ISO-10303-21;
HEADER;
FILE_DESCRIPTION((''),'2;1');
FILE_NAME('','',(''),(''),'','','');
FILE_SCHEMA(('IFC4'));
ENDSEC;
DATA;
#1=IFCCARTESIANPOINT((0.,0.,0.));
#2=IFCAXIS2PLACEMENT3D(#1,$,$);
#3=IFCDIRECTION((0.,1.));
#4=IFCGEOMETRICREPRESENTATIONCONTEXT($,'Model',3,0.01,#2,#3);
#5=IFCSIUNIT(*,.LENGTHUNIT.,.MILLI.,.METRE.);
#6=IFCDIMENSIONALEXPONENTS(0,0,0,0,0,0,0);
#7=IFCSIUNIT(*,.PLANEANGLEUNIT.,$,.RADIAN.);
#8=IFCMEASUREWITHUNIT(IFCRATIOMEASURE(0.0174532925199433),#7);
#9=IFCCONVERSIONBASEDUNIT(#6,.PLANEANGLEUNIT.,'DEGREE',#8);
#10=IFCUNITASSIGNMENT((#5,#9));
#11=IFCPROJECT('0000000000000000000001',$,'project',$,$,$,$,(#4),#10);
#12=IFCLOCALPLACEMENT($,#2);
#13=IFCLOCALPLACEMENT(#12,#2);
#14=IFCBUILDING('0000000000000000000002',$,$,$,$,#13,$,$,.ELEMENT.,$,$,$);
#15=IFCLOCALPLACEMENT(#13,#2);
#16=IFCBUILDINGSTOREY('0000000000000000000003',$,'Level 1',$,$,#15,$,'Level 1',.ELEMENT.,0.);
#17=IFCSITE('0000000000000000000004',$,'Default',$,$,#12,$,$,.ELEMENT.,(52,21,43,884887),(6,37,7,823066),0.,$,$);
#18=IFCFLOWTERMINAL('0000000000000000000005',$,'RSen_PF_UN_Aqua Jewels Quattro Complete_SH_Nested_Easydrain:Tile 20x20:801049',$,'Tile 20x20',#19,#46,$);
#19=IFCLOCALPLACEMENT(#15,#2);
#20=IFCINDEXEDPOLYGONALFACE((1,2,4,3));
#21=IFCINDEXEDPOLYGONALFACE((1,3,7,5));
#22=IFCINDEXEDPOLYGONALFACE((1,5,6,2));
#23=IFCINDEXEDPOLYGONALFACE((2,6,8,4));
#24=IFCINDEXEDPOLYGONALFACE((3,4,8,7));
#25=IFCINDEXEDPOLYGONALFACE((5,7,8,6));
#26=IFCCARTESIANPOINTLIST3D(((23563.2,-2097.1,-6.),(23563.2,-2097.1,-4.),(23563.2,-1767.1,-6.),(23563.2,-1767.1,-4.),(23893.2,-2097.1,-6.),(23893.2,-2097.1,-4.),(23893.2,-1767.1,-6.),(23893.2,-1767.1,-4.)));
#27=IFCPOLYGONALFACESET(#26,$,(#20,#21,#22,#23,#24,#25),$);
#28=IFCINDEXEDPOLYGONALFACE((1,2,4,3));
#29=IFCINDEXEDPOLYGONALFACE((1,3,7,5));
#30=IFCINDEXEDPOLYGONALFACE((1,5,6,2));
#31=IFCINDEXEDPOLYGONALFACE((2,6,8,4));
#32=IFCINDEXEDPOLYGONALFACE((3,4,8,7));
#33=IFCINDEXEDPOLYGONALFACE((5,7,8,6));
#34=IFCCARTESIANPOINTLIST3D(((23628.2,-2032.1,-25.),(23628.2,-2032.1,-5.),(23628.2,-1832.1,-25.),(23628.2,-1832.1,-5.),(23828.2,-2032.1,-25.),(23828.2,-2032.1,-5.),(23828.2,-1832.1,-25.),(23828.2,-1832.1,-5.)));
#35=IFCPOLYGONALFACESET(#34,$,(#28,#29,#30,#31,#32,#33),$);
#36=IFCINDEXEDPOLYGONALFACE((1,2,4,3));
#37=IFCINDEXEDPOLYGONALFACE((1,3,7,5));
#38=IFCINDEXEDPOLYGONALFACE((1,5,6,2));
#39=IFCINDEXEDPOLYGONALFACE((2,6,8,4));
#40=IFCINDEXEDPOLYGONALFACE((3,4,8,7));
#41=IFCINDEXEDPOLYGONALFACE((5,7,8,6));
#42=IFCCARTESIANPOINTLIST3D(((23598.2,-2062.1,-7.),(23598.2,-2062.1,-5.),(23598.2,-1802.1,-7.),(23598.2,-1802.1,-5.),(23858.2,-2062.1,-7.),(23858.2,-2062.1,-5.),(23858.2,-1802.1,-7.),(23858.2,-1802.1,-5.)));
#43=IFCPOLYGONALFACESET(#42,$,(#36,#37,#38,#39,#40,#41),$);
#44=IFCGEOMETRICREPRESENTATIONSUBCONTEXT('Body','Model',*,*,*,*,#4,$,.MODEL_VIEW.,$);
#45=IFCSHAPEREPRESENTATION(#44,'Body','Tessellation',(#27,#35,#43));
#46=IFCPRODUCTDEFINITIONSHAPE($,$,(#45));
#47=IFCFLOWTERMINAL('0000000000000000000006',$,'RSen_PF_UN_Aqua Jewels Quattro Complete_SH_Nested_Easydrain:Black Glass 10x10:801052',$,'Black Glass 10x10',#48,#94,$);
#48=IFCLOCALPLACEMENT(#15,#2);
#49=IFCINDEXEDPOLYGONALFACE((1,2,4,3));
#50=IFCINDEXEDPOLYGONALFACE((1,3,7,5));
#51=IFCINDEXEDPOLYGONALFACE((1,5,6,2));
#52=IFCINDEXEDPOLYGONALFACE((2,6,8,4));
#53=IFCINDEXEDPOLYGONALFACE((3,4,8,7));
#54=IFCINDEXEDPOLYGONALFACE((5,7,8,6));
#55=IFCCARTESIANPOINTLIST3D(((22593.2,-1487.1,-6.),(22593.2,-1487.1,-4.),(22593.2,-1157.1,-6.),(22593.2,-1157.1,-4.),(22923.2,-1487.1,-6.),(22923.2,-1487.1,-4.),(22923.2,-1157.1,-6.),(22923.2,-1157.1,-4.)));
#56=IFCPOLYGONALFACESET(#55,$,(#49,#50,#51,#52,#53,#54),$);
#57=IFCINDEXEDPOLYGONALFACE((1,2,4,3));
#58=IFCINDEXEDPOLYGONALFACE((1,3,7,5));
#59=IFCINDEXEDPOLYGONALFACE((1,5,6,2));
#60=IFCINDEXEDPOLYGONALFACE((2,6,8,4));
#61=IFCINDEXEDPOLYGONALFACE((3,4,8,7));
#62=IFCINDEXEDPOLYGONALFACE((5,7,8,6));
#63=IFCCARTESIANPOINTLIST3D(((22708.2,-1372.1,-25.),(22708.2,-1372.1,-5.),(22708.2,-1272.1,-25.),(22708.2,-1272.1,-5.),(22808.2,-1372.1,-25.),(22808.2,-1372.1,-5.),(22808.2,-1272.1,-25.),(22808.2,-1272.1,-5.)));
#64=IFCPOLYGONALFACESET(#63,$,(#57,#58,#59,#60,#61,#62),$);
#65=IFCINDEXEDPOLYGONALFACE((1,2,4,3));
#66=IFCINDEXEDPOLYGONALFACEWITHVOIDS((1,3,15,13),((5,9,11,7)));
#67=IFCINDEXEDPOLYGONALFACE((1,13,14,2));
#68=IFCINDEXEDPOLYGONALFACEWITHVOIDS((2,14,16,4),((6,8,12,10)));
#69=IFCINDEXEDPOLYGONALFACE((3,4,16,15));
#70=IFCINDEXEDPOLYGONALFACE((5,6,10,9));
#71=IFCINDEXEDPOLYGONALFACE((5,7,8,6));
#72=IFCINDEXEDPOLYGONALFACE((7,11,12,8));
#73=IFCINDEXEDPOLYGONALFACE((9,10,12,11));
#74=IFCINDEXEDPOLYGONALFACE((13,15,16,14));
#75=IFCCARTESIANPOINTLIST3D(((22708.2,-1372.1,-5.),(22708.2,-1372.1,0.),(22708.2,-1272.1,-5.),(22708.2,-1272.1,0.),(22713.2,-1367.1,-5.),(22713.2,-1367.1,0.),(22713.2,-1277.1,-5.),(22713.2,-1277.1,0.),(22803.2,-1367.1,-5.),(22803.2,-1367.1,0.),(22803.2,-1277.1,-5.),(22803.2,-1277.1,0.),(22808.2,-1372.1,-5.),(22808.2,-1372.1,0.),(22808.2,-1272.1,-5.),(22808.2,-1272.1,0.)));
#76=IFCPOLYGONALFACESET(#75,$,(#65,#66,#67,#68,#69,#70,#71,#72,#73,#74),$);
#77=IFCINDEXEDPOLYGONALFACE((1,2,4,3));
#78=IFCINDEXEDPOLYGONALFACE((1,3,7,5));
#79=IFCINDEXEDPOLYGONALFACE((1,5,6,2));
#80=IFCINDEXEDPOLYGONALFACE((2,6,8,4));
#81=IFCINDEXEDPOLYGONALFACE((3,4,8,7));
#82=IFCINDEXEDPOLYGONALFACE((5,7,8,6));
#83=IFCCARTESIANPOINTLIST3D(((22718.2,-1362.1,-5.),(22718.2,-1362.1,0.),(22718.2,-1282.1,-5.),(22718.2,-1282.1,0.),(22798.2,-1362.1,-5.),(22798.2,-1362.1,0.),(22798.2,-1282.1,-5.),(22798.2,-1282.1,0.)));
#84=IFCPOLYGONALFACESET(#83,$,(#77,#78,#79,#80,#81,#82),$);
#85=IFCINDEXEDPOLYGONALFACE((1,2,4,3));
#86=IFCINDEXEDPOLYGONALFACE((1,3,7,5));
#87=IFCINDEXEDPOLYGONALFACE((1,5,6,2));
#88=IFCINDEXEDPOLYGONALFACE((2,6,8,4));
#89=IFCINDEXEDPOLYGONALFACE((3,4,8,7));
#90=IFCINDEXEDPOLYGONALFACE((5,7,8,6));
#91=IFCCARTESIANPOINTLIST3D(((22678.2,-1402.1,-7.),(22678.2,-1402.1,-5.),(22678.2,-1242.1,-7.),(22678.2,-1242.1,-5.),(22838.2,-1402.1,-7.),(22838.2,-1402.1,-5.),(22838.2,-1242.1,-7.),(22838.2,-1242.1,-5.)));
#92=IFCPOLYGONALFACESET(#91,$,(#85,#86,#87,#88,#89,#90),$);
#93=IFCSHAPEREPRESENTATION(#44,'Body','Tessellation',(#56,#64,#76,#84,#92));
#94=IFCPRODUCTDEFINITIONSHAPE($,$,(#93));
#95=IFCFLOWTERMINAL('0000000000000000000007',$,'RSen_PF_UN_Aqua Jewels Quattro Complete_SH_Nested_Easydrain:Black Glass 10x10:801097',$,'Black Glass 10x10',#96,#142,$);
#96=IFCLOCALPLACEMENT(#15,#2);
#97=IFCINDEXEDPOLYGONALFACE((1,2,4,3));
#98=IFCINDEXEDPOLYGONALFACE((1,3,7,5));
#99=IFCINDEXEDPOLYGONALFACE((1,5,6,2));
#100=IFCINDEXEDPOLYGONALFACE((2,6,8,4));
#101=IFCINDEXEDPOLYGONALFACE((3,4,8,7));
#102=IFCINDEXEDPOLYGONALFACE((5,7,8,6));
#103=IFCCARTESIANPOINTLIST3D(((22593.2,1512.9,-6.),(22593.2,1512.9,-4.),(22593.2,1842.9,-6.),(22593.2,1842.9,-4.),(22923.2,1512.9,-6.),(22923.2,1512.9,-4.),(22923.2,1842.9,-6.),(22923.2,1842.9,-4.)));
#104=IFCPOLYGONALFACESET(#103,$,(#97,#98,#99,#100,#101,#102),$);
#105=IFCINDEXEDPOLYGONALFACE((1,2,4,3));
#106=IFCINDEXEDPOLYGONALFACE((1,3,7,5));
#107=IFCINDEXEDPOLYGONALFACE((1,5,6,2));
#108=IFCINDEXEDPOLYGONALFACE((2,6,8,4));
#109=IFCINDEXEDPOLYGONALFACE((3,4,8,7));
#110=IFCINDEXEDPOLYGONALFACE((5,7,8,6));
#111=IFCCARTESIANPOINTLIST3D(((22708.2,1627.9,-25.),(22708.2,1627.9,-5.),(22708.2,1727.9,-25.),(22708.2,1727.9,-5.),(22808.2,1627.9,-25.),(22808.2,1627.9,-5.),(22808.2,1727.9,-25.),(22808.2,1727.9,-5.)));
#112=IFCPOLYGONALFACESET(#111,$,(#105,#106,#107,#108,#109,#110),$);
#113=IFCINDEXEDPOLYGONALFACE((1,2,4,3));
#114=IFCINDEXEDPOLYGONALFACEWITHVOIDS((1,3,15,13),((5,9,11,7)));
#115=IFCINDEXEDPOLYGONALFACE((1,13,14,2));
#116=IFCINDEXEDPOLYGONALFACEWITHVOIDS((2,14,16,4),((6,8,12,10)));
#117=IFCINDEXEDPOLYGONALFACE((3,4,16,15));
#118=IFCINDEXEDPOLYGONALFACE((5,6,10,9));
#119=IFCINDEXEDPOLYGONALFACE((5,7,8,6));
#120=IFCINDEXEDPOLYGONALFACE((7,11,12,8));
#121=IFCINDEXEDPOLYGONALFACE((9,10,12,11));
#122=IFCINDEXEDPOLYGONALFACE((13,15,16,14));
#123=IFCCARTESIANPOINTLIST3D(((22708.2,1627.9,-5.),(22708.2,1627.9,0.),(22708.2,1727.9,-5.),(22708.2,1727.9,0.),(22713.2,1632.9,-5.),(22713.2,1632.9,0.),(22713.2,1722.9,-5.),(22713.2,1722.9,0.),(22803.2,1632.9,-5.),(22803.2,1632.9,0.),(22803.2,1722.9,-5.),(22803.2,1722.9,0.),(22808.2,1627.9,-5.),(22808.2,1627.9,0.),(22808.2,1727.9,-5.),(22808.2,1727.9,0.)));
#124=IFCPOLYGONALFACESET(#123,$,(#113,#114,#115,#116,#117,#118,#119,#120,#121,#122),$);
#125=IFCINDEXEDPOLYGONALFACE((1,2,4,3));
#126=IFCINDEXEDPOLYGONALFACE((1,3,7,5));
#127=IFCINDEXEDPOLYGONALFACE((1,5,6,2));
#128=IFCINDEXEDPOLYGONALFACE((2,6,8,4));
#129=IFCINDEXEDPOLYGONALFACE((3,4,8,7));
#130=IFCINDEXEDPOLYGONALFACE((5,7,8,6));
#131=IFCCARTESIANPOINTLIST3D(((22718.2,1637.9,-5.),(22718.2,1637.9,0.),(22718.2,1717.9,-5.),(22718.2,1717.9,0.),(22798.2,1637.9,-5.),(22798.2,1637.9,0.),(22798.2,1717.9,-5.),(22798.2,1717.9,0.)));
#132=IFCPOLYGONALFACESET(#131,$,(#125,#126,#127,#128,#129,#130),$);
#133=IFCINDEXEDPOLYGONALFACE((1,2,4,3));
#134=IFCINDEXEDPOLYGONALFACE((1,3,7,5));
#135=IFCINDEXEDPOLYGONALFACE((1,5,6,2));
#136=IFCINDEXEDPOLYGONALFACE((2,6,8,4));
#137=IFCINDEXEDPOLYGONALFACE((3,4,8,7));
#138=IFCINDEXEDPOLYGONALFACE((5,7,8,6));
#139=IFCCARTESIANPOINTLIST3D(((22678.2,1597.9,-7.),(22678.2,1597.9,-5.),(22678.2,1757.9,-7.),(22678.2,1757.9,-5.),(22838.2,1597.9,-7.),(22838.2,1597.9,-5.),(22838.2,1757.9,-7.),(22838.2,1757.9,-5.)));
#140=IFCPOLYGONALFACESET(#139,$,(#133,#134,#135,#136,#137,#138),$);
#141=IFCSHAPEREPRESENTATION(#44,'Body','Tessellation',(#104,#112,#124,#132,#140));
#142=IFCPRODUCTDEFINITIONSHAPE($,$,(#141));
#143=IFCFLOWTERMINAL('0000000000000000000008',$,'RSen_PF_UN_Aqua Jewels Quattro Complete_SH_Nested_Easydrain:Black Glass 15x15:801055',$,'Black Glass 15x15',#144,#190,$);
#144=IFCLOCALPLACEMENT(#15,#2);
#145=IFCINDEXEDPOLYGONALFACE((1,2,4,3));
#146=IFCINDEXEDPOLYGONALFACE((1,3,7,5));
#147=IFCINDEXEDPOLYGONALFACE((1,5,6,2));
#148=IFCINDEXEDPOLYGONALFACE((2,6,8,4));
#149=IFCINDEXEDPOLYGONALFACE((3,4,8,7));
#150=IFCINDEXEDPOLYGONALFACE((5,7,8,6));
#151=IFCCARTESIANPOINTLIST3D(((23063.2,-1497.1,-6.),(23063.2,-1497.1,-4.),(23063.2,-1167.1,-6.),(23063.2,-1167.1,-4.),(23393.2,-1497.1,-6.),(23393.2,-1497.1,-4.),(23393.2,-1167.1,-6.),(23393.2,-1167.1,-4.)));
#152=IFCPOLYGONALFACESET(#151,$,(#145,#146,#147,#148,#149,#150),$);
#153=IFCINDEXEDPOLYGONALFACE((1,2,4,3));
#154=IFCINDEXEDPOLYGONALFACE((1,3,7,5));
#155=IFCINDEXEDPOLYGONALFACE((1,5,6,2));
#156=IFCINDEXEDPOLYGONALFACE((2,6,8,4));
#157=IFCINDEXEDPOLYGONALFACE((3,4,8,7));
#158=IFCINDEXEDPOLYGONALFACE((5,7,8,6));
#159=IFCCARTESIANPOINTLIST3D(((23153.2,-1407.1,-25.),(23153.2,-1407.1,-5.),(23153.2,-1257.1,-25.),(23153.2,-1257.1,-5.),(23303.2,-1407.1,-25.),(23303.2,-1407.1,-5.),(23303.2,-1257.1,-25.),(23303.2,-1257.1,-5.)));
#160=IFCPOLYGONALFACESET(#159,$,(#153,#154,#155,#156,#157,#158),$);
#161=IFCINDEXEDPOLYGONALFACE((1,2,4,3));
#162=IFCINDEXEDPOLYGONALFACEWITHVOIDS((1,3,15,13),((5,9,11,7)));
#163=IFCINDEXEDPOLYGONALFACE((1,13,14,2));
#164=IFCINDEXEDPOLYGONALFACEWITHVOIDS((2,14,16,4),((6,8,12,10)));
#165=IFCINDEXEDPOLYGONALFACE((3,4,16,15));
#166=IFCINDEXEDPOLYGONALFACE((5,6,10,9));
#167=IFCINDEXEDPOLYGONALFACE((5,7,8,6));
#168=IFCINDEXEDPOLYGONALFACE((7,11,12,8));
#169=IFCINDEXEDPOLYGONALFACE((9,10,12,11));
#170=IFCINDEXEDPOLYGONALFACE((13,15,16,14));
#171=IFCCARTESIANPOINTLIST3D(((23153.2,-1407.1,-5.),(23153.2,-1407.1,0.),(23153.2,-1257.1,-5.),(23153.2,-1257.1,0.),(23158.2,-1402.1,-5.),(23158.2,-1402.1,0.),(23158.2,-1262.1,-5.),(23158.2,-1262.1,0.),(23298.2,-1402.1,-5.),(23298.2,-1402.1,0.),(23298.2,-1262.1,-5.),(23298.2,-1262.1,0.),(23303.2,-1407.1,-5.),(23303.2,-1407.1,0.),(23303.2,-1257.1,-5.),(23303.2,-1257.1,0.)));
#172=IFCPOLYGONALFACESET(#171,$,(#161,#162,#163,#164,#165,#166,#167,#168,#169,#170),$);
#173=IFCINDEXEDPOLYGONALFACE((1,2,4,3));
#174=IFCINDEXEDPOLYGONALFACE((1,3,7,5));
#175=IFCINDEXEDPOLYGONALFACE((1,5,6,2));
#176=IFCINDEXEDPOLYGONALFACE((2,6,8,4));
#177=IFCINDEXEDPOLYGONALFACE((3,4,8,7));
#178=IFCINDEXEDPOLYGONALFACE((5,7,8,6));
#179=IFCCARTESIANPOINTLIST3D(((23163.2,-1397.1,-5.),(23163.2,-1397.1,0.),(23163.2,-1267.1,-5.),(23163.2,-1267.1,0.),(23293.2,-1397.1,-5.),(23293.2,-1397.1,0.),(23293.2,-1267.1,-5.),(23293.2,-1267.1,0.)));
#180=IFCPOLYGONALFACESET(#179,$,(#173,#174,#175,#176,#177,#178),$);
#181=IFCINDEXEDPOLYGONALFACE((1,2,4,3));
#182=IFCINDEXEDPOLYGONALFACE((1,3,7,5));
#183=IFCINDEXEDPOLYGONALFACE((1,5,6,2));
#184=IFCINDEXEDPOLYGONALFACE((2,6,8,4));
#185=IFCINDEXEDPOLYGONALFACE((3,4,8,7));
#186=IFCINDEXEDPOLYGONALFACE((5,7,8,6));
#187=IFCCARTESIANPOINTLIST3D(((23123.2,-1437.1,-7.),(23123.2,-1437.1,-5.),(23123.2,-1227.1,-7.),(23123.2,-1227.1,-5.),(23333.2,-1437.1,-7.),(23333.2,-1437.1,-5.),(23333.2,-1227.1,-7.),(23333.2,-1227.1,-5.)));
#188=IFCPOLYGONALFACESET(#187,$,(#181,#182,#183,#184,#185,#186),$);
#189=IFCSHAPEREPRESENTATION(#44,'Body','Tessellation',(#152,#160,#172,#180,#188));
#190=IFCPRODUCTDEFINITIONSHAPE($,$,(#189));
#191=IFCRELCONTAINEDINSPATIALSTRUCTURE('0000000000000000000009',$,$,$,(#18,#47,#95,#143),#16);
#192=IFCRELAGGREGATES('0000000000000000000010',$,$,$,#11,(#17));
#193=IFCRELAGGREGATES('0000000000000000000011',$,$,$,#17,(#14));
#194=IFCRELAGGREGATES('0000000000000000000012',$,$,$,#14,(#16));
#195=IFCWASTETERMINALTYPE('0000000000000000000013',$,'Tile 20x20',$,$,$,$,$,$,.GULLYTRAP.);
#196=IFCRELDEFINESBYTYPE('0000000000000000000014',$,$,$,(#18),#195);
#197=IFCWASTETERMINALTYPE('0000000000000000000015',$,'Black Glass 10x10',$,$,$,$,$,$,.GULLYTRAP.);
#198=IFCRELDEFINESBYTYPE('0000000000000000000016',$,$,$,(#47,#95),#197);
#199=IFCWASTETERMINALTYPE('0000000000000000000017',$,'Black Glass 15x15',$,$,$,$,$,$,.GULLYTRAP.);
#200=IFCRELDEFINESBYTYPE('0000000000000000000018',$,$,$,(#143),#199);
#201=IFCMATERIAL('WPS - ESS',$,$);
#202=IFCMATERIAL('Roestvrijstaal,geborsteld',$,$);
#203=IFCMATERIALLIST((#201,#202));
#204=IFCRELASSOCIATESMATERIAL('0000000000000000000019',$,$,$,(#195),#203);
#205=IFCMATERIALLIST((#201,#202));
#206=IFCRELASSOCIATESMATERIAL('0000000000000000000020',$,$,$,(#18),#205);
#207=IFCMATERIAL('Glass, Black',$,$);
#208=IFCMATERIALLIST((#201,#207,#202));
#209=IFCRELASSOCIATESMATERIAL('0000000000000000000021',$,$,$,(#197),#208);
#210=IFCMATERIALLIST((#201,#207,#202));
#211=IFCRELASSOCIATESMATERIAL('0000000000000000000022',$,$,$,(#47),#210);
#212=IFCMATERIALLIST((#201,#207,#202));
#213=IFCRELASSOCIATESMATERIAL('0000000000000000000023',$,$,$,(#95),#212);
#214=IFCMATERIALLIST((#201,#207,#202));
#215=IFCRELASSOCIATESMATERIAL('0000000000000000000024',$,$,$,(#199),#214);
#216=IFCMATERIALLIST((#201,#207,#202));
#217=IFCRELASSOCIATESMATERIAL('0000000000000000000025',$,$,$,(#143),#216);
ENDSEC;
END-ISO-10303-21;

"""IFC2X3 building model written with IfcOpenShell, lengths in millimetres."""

from ifc_helpers import new_model, entity, si_unit, converted_unit, direction, frame, frame_2d, origin, origin_2d_with_axis, place, context, subcontext, project, spatial, polyline, rectangle, outline, extrude, source, transform, mapped, material, material_list, type_object, type_shapes, element, save


model = new_model("IFC2X3")

# Units and contexts
model_context = context("Model", 3, precision=0.01, world=origin(), true_north=direction((0.0, 1.0)))
body_context = subcontext(model_context, "Body", "Model", "MODEL_VIEW")
ifc_project = project(units=[si_unit("LENGTHUNIT", "METRE", prefix="MILLI"), converted_unit("PLANEANGLEUNIT", "DEGREE", entity("IfcRatioMeasure", 0.0174532925199433), si_unit("PLANEANGLEUNIT", "RADIAN"), dimensions=[0, 0, 0, 0, 0, 0, 0])], contexts=[model_context])

# Site, building, storey
site_placement = place(None, origin())
site = spatial("IfcSite", under=ifc_project, at=site_placement, Name="Default", CompositionType="ELEMENT", RefLatitude=(52, 21, 43, 884887), RefLongitude=(6, 37, 7, 823066), RefElevation=0.0)
building_placement = place(site_placement, origin())
building = spatial("IfcBuilding", under=site, at=building_placement, CompositionType="ELEMENT")
storey_placement = place(building_placement, origin())
storey = spatial("IfcBuildingStorey", under=building, at=storey_placement, Name="Level 1", LongName="Level 1", CompositionType="ELEMENT", Elevation=0.0)

# Flow terminals
ifc_material_1 = material(Name="WPS - ESS")
ifc_material_2 = material(Name="Roestvrijstaal,geborsteld")
ifc_material_list_1 = material_list([ifc_material_1, ifc_material_2])
ifc_material_list_2 = material_list([ifc_material_1, ifc_material_2])
waste_terminal_type_1 = type_object("IfcWasteTerminalType", Name="Tile 20x20", PredefinedType="GULLYTRAP", material=ifc_material_list_2)
shared_shape_1 = source(origin(), body_context, "Body", "SweptSolid", [
    extrude(rectangle(XDim=330.0, YDim=330.0, at=origin_2d_with_axis()), frame((5.0, -10.0, -6.0), z_axis=(0.0, 0.0, 1.0), x_axis=(-1.0, 0.0, 0.0)), (0.0, 0.0, 1.0), 2.0),
    extrude(rectangle(XDim=200.0, YDim=200.0, at=origin_2d_with_axis()), frame((5.0, -10.0, -25.0), z_axis=(0.0, 0.0, 1.0), x_axis=(-1.0, 0.0, 0.0)), (0.0, 0.0, 1.0), 20.0),
    extrude(rectangle(XDim=260.0, YDim=260.0, at=origin_2d_with_axis()), frame((5.0, -10.0, -7.0), z_axis=(0.0, 0.0, 1.0), x_axis=(-1.0, 0.0, 0.0)), (0.0, 0.0, 1.0), 2.0),
])
type_shapes(waste_terminal_type_1, [shared_shape_1])
flow_terminal_1_placement = place(storey_placement, frame((23723.2, -1922.1, 0.0)))
element("IfcFlowTerminal", 1, at=flow_terminal_1_placement, inside=storey, type_object=waste_terminal_type_1, material=ifc_material_list_1, Name="RSen_PF_UN_Aqua Jewels Quattro Complete_SH_Nested_Easydrain:Tile 20x20:801049", ObjectType="Tile 20x20", context=body_context, shape_type="MappedRepresentation", body=[
    mapped(shared_shape_1, transform((0.0, 0.0, 0.0), scale=1.0)),
])
ifc_material_3 = material(Name="Glass, Black")
ifc_material_list_3 = material_list([ifc_material_1, ifc_material_3, ifc_material_2])
ifc_material_list_4 = material_list([ifc_material_1, ifc_material_3, ifc_material_2])
waste_terminal_type_2 = type_object("IfcWasteTerminalType", Name="Black Glass 10x10", PredefinedType="GULLYTRAP", material=ifc_material_list_4)
shared_shape_2 = source(origin(), body_context, "Body", "SweptSolid", [
    extrude(rectangle(XDim=330.0, YDim=330.0, at=origin_2d_with_axis()), frame((0.0, 0.0, -6.0), z_axis=(0.0, 0.0, 1.0), x_axis=(-1.0, 0.0, 0.0)), (0.0, 0.0, 1.0), 2.0),
    extrude(rectangle(XDim=100.0, YDim=100.0, at=origin_2d_with_axis()), frame((0.0, 0.0, -25.0), z_axis=(0.0, 0.0, 1.0), x_axis=(-1.0, 0.0, 0.0)), (0.0, 0.0, 1.0), 20.0),
    extrude(outline(polyline([(-50.0, -50.0), (50.0, -50.0), (50.0, 50.0), (-50.0, 50.0), (-50.0, -50.0)]), holes=[polyline([(-45.0, -45.0), (-45.0, 45.0), (45.0, 45.0), (45.0, -45.0), (-45.0, -45.0)])]), frame((0.0, 0.0, -5.0), z_axis=(0.0, 0.0, 1.0), x_axis=(-1.0, 0.0, 0.0)), (0.0, 0.0, 1.0), 5.0),
    extrude(rectangle(XDim=80.0, YDim=80.0, at=origin_2d_with_axis()), frame((0.0, 0.0, -5.0), z_axis=(0.0, 0.0, 1.0), x_axis=(-1.0, 0.0, 0.0)), (0.0, 0.0, 1.0), 5.0),
    extrude(rectangle(XDim=160.0, YDim=160.0, at=origin_2d_with_axis()), frame((0.0, 0.0, -7.0), z_axis=(0.0, 0.0, 1.0), x_axis=(-1.0, 0.0, 0.0)), (0.0, 0.0, 1.0), 2.0),
])
type_shapes(waste_terminal_type_2, [shared_shape_2])
flow_terminal_2_placement = place(storey_placement, frame((22758.2, -1322.1, 0.0)))
element("IfcFlowTerminal", 2, at=flow_terminal_2_placement, inside=storey, type_object=waste_terminal_type_2, material=ifc_material_list_3, Name="RSen_PF_UN_Aqua Jewels Quattro Complete_SH_Nested_Easydrain:Black Glass 10x10:801052", ObjectType="Black Glass 10x10", context=body_context, shape_type="MappedRepresentation", body=[
    mapped(shared_shape_2, transform((0.0, 0.0, 0.0), scale=1.0)),
])
ifc_material_list_5 = material_list([ifc_material_1, ifc_material_3, ifc_material_2])
flow_terminal_3_placement = place(storey_placement, frame((22758.2, 1677.9, 0.0)))
element("IfcFlowTerminal", 3, at=flow_terminal_3_placement, inside=storey, type_object=waste_terminal_type_2, material=ifc_material_list_5, Name="RSen_PF_UN_Aqua Jewels Quattro Complete_SH_Nested_Easydrain:Black Glass 10x10:801097", ObjectType="Black Glass 10x10", context=body_context, shape_type="MappedRepresentation", body=[
    mapped(shared_shape_2, transform((0.0, 0.0, 0.0), scale=1.0)),
])
ifc_material_list_6 = material_list([ifc_material_1, ifc_material_3, ifc_material_2])
ifc_material_list_7 = material_list([ifc_material_1, ifc_material_3, ifc_material_2])
waste_terminal_type_3 = type_object("IfcWasteTerminalType", Name="Black Glass 15x15", PredefinedType="GULLYTRAP", material=ifc_material_list_7)
shared_shape_3 = source(origin(), body_context, "Body", "SweptSolid", [
    extrude(rectangle(XDim=330.0, YDim=330.0, at=origin_2d_with_axis()), frame((5.0, -10.0, -6.0), z_axis=(0.0, 0.0, 1.0), x_axis=(-1.0, 0.0, 0.0)), (0.0, 0.0, 1.0), 2.0),
    extrude(rectangle(XDim=150.0, YDim=150.0, at=origin_2d_with_axis()), frame((5.0, -10.0, -25.0), z_axis=(0.0, 0.0, 1.0), x_axis=(-1.0, 0.0, 0.0)), (0.0, 0.0, 1.0), 20.0),
    extrude(outline(polyline([(-75.0, -75.0), (75.0, -75.0), (75.0, 75.0), (-75.0, 75.0), (-75.0, -75.0)]), holes=[polyline([(-70.0, -70.0), (-70.0, 70.0), (70.0, 70.0), (70.0, -70.0), (-70.0, -70.0)])]), frame((5.0, -10.0, -5.0), z_axis=(0.0, 0.0, 1.0), x_axis=(-1.0, 0.0, 0.0)), (0.0, 0.0, 1.0), 5.0),
    extrude(rectangle(XDim=130.0, YDim=130.0, at=frame_2d((0.0, 0.0), x_axis=(1.0, 0.0))), frame((5.0, -10.0, -5.0), z_axis=(0.0, 0.0, 1.0), x_axis=(-1.0, 0.0, 0.0)), (0.0, 0.0, 1.0), 5.0),
    extrude(rectangle(XDim=210.0, YDim=210.0, at=origin_2d_with_axis()), frame((5.0, -10.0, -7.0), z_axis=(0.0, 0.0, 1.0), x_axis=(-1.0, 0.0, 0.0)), (0.0, 0.0, 1.0), 2.0),
])
type_shapes(waste_terminal_type_3, [shared_shape_3])
flow_terminal_4_placement = place(storey_placement, frame((23223.2, -1322.1, 0.0)))
element("IfcFlowTerminal", 4, at=flow_terminal_4_placement, inside=storey, type_object=waste_terminal_type_3, material=ifc_material_list_6, Name="RSen_PF_UN_Aqua Jewels Quattro Complete_SH_Nested_Easydrain:Black Glass 15x15:801055", ObjectType="Black Glass 15x15", context=body_context, shape_type="MappedRepresentation", body=[
    mapped(shared_shape_3, transform((0.0, 0.0, 0.0), scale=1.0)),
])

save(model, "model.ifc")
